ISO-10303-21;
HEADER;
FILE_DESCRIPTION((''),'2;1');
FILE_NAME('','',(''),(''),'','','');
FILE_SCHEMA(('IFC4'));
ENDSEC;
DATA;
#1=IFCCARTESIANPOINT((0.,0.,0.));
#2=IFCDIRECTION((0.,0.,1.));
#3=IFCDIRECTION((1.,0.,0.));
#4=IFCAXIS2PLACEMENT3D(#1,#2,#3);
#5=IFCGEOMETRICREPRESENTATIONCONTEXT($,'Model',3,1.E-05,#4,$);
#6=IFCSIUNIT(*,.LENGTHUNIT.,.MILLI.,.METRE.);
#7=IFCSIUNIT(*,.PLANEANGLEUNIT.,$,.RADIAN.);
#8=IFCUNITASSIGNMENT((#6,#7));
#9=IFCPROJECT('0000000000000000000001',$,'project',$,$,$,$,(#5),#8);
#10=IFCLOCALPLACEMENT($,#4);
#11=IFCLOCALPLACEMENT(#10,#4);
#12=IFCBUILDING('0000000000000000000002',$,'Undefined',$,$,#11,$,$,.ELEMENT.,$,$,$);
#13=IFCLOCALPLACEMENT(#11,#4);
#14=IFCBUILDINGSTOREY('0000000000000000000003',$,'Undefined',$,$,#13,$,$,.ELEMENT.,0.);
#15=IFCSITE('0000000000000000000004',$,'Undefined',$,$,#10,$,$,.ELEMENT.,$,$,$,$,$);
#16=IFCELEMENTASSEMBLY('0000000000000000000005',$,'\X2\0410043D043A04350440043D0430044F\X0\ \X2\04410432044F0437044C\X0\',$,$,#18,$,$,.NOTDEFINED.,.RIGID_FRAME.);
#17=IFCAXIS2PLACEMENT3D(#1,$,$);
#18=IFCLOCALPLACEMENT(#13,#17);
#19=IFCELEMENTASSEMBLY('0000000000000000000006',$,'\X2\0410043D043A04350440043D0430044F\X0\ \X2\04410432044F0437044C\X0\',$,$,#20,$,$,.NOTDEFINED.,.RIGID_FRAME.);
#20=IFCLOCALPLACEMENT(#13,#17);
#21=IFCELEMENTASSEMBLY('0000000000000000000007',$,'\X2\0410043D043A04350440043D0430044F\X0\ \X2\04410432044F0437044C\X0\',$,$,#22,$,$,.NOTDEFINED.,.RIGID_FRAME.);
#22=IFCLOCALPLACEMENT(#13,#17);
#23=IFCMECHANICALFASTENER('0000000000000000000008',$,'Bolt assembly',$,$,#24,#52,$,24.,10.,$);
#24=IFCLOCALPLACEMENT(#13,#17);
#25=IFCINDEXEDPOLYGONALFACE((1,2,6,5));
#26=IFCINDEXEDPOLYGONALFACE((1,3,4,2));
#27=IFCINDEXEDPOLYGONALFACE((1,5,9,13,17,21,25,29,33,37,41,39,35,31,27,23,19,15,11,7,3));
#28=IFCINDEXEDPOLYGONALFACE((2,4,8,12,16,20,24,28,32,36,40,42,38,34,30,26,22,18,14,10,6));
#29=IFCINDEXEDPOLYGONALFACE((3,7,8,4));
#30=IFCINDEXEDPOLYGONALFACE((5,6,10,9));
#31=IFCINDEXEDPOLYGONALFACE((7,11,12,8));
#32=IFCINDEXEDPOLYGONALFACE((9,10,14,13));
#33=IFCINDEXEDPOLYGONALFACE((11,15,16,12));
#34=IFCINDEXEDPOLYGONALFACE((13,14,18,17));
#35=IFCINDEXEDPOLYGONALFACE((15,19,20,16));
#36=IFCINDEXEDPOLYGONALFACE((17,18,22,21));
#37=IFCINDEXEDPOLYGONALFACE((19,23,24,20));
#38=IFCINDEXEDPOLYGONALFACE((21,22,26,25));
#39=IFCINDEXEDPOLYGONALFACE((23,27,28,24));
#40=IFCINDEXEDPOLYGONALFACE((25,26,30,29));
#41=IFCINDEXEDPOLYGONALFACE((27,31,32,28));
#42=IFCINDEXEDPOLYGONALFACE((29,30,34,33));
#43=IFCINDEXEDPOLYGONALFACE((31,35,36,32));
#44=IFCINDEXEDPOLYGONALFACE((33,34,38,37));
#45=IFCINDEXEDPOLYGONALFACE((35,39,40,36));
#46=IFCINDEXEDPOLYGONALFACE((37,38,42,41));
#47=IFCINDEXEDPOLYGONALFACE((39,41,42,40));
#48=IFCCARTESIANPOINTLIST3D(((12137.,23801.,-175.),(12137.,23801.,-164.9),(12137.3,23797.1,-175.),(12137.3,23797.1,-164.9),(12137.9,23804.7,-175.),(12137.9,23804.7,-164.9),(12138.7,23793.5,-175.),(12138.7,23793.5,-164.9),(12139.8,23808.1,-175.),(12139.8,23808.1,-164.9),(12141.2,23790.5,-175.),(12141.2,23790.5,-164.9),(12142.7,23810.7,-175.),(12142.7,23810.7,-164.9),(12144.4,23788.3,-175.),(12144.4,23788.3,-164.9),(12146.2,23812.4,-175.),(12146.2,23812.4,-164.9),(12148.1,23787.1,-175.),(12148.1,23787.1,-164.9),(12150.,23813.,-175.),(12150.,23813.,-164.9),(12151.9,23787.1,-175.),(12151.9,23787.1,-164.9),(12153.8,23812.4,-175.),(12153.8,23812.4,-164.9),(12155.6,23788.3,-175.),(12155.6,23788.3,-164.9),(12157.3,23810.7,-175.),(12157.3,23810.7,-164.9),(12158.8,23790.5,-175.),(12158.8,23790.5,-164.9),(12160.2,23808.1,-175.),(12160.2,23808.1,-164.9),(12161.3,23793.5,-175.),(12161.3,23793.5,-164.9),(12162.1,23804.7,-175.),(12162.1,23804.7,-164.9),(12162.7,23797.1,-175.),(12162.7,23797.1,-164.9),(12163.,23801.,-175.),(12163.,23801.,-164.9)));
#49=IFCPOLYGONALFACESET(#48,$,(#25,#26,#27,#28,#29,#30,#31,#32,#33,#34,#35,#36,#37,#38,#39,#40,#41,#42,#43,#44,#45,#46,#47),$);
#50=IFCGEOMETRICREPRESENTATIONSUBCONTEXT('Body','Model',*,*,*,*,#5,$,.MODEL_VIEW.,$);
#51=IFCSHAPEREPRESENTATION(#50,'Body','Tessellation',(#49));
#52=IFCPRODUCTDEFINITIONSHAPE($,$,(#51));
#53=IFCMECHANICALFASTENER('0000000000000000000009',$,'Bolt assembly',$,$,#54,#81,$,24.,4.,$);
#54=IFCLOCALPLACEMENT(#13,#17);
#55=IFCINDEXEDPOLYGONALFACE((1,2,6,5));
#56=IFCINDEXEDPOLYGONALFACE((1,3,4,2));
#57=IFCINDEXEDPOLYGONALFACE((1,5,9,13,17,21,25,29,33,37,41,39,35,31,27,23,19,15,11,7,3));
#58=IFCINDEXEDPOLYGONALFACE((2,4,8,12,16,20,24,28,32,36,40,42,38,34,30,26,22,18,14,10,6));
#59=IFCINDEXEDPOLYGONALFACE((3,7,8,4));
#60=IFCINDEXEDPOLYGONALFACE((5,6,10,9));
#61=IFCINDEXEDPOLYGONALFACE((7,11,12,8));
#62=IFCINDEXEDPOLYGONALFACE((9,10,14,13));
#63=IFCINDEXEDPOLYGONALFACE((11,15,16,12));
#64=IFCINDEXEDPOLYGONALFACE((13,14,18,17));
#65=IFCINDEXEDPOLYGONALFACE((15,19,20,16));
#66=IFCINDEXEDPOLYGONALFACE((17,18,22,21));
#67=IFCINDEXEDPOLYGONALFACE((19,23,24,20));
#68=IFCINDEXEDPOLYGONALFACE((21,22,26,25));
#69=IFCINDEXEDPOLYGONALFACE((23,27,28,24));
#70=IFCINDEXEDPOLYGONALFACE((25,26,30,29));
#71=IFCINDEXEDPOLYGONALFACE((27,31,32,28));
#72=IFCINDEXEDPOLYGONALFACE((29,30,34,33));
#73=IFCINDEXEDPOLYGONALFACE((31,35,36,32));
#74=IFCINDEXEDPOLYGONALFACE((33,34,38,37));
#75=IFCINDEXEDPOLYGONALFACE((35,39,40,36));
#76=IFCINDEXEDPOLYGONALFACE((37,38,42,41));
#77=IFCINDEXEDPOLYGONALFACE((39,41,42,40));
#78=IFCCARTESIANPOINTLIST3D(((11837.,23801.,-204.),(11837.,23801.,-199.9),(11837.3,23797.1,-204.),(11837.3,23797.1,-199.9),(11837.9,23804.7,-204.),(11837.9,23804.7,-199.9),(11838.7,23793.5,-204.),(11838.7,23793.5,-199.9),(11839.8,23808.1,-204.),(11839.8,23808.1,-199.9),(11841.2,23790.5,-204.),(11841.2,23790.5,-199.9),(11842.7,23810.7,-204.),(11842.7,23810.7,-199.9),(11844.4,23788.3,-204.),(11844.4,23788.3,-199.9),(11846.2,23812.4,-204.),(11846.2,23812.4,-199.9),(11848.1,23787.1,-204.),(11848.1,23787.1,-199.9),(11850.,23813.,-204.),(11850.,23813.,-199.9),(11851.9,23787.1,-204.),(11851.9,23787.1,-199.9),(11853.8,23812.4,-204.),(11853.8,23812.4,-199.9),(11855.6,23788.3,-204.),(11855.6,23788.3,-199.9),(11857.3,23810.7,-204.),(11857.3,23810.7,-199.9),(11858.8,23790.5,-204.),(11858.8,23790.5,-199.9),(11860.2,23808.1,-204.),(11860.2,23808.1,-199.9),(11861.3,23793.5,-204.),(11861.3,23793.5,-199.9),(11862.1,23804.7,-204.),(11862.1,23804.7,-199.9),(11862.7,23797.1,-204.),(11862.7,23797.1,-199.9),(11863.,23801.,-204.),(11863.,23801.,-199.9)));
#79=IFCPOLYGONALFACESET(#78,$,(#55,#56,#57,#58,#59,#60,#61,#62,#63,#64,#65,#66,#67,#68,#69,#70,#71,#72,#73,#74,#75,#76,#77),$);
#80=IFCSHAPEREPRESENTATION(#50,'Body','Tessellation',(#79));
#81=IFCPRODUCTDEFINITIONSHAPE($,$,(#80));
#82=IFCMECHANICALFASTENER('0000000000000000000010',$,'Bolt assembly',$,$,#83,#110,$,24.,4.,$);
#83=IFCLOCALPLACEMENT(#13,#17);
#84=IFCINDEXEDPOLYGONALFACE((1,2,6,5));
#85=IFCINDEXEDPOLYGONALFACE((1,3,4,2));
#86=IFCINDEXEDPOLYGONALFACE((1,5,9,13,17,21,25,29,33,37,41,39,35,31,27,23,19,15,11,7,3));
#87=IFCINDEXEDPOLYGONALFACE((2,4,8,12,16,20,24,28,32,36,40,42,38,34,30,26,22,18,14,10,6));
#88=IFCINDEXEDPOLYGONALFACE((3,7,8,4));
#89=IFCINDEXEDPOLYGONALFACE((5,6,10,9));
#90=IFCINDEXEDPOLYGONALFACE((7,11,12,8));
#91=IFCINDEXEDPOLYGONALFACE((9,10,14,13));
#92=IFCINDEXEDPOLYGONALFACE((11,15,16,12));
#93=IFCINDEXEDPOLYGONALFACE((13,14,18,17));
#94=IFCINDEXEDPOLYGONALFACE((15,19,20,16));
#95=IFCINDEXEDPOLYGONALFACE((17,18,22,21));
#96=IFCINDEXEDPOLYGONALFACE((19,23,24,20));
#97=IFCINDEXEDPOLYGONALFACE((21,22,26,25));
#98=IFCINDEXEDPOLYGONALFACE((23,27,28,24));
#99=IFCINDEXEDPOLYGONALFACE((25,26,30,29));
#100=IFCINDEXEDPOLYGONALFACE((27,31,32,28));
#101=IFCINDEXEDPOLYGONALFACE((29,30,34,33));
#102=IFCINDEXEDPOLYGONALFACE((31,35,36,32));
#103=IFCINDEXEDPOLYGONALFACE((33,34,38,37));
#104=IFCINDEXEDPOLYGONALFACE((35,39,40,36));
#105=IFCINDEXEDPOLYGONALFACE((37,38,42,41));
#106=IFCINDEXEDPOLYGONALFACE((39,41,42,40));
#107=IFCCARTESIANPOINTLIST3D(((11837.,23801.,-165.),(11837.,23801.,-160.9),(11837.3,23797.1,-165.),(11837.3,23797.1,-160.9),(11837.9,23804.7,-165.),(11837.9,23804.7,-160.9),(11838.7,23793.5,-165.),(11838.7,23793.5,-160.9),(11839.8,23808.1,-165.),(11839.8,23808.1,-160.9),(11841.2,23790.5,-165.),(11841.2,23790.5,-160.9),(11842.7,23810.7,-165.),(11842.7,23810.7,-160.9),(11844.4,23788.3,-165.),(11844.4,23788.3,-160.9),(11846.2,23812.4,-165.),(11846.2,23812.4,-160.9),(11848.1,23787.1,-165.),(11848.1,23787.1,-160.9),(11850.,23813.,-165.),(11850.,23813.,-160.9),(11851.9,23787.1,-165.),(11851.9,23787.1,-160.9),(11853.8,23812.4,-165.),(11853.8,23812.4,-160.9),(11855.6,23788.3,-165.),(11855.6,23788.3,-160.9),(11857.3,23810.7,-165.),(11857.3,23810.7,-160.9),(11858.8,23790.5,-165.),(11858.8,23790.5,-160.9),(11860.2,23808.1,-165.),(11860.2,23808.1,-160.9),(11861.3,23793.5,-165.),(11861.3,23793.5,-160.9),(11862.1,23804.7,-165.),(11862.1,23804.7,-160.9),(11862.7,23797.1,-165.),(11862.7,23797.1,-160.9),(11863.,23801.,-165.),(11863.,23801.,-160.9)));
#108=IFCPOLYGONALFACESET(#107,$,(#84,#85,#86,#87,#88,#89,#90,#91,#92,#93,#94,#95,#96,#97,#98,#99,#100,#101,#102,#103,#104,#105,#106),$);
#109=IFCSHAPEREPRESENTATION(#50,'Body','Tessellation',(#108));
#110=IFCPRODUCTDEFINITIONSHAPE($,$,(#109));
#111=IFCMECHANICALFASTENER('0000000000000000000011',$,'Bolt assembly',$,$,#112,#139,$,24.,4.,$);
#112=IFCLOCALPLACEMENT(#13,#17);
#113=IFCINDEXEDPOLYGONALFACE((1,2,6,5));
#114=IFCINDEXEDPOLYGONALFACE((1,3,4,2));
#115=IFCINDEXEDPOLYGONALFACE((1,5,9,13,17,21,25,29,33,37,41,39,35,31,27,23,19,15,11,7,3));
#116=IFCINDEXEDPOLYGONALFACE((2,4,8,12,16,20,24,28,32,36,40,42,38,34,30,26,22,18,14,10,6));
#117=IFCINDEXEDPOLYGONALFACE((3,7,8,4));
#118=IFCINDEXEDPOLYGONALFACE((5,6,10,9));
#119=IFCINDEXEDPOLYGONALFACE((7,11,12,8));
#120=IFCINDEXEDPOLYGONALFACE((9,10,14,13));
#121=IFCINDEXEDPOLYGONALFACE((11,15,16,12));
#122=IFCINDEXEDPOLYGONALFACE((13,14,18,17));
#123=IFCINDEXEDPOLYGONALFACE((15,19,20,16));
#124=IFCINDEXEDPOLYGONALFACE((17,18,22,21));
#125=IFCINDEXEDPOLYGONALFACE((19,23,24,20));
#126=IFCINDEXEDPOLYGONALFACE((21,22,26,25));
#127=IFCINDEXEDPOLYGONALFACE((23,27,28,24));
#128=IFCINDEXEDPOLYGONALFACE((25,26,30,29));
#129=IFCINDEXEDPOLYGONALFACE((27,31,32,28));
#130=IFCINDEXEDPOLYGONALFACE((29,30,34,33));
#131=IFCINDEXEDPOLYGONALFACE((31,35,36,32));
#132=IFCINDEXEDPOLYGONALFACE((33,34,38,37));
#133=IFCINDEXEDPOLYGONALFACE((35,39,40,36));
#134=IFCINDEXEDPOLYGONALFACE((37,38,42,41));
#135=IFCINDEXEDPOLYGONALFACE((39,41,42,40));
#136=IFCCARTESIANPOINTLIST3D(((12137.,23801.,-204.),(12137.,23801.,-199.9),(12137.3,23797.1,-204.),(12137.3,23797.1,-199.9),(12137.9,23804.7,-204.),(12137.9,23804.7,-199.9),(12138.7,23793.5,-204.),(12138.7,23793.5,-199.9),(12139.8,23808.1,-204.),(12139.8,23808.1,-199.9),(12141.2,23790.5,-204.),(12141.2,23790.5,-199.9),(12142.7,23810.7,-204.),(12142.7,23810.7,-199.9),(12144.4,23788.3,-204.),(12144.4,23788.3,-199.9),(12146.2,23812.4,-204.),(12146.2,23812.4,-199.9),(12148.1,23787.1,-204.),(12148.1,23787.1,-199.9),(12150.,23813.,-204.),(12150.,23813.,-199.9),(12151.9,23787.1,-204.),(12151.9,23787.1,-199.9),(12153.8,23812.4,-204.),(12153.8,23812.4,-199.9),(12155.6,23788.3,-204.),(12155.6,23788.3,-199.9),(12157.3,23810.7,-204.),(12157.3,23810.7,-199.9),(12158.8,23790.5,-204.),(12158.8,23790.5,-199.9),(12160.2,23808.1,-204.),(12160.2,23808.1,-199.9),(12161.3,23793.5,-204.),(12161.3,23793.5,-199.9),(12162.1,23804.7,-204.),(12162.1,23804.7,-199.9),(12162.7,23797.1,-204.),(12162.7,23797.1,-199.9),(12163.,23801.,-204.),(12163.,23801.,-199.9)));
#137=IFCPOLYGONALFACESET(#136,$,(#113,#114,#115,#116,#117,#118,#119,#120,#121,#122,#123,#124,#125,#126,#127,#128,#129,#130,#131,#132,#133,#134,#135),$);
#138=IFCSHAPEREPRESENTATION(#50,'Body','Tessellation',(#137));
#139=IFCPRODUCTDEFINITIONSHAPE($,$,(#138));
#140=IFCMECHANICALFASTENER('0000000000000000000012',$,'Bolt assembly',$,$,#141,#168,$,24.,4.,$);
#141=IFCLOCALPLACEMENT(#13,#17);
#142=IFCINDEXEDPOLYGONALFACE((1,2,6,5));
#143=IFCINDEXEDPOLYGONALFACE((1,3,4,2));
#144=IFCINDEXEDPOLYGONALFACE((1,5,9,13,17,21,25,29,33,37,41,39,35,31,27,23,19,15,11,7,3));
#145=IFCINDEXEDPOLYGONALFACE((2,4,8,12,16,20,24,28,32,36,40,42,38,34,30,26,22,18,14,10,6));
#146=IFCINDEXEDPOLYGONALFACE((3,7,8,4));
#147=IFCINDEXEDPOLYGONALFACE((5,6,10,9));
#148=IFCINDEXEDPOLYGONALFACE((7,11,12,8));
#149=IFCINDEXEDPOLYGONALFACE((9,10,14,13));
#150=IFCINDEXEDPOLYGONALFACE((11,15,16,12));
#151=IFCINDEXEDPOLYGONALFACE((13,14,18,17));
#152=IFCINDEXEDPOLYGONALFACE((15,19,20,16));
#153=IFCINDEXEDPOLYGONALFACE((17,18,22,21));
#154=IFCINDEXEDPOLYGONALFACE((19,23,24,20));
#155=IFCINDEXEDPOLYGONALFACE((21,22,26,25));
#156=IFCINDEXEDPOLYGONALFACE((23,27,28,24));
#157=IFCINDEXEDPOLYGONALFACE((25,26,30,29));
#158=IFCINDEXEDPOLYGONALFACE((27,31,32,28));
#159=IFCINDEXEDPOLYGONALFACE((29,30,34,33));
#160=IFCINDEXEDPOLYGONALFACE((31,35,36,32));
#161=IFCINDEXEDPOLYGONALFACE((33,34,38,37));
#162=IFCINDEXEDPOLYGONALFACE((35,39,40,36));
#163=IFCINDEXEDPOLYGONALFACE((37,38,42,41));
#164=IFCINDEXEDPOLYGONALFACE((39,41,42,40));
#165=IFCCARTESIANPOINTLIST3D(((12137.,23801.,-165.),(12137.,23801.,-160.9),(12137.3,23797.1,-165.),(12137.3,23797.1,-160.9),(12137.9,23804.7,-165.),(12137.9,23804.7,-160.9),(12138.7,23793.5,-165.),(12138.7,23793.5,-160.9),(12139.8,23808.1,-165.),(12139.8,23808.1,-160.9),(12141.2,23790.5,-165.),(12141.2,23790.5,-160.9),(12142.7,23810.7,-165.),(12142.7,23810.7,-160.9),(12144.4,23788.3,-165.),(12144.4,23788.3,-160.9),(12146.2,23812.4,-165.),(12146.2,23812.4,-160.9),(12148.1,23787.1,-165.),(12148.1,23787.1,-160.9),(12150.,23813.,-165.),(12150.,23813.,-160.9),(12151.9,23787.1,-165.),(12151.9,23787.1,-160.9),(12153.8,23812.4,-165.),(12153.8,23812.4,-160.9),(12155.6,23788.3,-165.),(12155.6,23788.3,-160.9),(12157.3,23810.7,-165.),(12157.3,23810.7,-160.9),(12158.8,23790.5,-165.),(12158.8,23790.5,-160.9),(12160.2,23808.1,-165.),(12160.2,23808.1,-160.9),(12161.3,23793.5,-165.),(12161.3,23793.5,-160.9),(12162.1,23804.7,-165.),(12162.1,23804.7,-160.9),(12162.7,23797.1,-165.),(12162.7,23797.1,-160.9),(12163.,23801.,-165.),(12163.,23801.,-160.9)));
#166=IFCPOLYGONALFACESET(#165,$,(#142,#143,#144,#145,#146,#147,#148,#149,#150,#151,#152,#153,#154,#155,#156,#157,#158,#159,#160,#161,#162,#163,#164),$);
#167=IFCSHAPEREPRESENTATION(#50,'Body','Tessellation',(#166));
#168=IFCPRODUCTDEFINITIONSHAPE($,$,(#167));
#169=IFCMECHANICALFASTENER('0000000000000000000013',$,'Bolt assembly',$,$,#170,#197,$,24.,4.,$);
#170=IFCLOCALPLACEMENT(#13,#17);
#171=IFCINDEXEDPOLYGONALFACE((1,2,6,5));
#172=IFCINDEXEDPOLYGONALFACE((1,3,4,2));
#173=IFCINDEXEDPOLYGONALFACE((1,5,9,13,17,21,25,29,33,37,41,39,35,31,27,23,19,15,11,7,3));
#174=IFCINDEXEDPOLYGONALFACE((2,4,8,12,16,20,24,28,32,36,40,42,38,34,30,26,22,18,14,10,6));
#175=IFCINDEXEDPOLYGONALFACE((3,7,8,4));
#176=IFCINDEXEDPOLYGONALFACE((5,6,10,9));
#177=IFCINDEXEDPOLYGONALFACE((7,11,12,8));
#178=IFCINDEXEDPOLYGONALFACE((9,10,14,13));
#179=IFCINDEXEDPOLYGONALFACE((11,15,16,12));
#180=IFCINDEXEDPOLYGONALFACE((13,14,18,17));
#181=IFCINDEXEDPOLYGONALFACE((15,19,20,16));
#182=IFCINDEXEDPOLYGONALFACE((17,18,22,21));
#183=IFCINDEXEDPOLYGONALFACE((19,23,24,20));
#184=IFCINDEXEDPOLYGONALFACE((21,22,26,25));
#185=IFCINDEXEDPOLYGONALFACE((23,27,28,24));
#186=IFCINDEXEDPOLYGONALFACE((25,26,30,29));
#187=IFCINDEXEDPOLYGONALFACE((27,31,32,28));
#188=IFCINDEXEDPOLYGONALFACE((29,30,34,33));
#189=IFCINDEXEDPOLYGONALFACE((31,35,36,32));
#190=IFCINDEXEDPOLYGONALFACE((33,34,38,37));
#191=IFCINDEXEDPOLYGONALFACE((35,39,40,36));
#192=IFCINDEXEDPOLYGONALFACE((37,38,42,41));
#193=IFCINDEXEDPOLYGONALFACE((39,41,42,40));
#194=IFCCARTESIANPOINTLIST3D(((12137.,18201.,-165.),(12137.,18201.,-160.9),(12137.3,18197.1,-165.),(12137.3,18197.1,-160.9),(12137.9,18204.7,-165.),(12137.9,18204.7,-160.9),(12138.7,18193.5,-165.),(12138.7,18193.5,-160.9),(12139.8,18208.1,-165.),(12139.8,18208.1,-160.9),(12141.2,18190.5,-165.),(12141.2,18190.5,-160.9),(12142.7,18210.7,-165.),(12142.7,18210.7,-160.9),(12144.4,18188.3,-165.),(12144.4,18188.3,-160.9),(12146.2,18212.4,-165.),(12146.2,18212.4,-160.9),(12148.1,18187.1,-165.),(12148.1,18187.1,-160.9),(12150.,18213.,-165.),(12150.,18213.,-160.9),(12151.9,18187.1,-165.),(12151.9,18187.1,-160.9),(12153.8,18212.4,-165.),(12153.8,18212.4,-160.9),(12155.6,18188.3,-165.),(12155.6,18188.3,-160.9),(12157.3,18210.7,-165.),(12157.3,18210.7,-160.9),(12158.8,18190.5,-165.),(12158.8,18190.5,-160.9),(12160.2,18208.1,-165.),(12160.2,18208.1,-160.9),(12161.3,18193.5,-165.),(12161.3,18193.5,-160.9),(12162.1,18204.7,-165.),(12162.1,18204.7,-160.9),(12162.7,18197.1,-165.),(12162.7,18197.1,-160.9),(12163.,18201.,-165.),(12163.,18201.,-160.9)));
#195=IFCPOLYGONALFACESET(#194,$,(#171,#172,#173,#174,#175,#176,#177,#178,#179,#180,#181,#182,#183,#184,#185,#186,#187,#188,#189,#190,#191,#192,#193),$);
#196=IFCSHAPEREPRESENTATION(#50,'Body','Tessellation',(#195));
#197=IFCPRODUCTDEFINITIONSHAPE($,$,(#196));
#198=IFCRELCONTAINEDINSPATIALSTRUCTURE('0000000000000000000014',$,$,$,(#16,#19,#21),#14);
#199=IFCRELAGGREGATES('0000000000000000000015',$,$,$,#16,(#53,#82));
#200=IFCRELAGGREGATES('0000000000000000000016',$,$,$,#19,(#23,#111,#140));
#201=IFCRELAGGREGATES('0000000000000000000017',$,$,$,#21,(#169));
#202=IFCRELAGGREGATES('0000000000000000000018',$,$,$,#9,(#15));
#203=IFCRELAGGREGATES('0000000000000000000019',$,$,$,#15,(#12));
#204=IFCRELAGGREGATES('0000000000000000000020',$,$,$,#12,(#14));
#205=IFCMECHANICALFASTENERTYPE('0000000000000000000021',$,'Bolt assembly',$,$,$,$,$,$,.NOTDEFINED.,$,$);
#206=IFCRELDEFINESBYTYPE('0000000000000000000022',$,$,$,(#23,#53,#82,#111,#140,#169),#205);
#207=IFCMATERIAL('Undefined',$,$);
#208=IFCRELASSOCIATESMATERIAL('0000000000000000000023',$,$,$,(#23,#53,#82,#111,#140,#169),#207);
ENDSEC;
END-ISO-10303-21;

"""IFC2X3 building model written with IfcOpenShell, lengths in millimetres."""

from ifc_helpers import new_model, si_unit, frame, origin_with_axes, origin_2d_with_axis, place, context, subcontext, project, spatial, circle, extrude, source, transform, mapped, material, type_object, element, aggregate, save


model = new_model("IFC2X3")

# Units and contexts
model_context = context("Model", 3, precision=1e-05, world=origin_with_axes())
body_context = subcontext(model_context, "Body", "Model", "MODEL_VIEW")
ifc_project = project(units=[si_unit("LENGTHUNIT", "METRE", prefix="MILLI"), si_unit("PLANEANGLEUNIT", "RADIAN")], contexts=[model_context])

# Site, building, storey
site_placement = place(None, origin_with_axes())
site = spatial("IfcSite", under=ifc_project, at=site_placement, Name="Undefined", CompositionType="ELEMENT")
building_placement = place(site_placement, origin_with_axes())
building = spatial("IfcBuilding", under=site, at=building_placement, Name="Undefined", CompositionType="ELEMENT")
storey_placement = place(building_placement, origin_with_axes())
storey = spatial("IfcBuildingStorey", under=building, at=storey_placement, Name="Undefined", CompositionType="ELEMENT", Elevation=0.0)

# Element assemblies
assembly_1_placement = place(storey_placement, origin_with_axes())
assembly_1 = element("IfcElementAssembly", 1, at=assembly_1_placement, inside=storey, Name="Анкерная связь", AssemblyPlace="NOTDEFINED", PredefinedType="RIGID_FRAME")
assembly_2_placement = place(storey_placement, origin_with_axes())
assembly_2 = element("IfcElementAssembly", 2, at=assembly_2_placement, inside=storey, Name="Анкерная связь", AssemblyPlace="NOTDEFINED", PredefinedType="RIGID_FRAME")
assembly_3_placement = place(storey_placement, origin_with_axes())
assembly_3 = element("IfcElementAssembly", 3, at=assembly_3_placement, inside=storey, Name="Анкерная связь", AssemblyPlace="NOTDEFINED", PredefinedType="RIGID_FRAME")

# Shared definitions
ifc_material_1 = material(Name="Undefined")
mechanical_fastener_type = type_object("IfcMechanicalFastenerType", Name="Bolt assembly")

# Mechanical fasteners
shared_shape_1 = source(origin_with_axes(), body_context, "Body", "SweptSolid", [
    extrude(circle(Radius=13.0, at=origin_2d_with_axis()), frame((0.0, 0.0, 0.0), z_axis=(0.0, 1.0, 0.0), x_axis=(1.0, 0.0, 0.0)), (0.0, 0.0, 1.0), 10.1),
])
mechanical_fastener_1_placement = place(assembly_2_placement, frame((12150.0, 23800.0, -175.0), z_axis=(1.0, 0.0, 0.0), x_axis=(0.0, 1.0, 0.0)))
mechanical_fastener_1 = element("IfcMechanicalFastener", 4, at=mechanical_fastener_1_placement, type_object=mechanical_fastener_type, material=ifc_material_1, Name="Bolt assembly", NominalDiameter=24.0, NominalLength=10.0, context=body_context, shape_type="MappedRepresentation", body=[
    mapped(shared_shape_1, transform((0.0, 0.0, 0.0))),
])
shared_shape_2 = source(origin_with_axes(), body_context, "Body", "SweptSolid", [
    extrude(circle(Radius=13.0, at=origin_2d_with_axis()), frame((0.0, -4.0, 0.0), z_axis=(0.0, 1.0, 0.0), x_axis=(1.0, 0.0, 0.0)), (0.0, 0.0, 1.0), 4.1),
])
mechanical_fastener_2_placement = place(assembly_1_placement, frame((11850.0, 23800.0, -200.0), z_axis=(1.0, 0.0, 0.0), x_axis=(0.0, 1.0, 0.0)))
mechanical_fastener_2 = element("IfcMechanicalFastener", 5, at=mechanical_fastener_2_placement, type_object=mechanical_fastener_type, material=ifc_material_1, Name="Bolt assembly", NominalDiameter=24.0, NominalLength=4.0, context=body_context, shape_type="MappedRepresentation", body=[
    mapped(shared_shape_2, transform((0.0, 0.0, 0.0))),
])
mechanical_fastener_3_placement = place(assembly_1_placement, frame((11850.0, 23800.0, -161.0), z_axis=(1.0, 0.0, 0.0), x_axis=(0.0, 1.0, 0.0)))
mechanical_fastener_3 = element("IfcMechanicalFastener", 6, at=mechanical_fastener_3_placement, type_object=mechanical_fastener_type, material=ifc_material_1, Name="Bolt assembly", NominalDiameter=24.0, NominalLength=4.0, context=body_context, shape_type="MappedRepresentation", body=[
    mapped(shared_shape_2, transform((0.0, 0.0, 0.0))),
])
aggregate(assembly_1, [mechanical_fastener_2, mechanical_fastener_3])
mechanical_fastener_4_placement = place(assembly_2_placement, frame((12150.0, 23800.0, -200.0), z_axis=(1.0, 0.0, 0.0), x_axis=(0.0, 1.0, 0.0)))
mechanical_fastener_4 = element("IfcMechanicalFastener", 7, at=mechanical_fastener_4_placement, type_object=mechanical_fastener_type, material=ifc_material_1, Name="Bolt assembly", NominalDiameter=24.0, NominalLength=4.0, context=body_context, shape_type="MappedRepresentation", body=[
    mapped(shared_shape_2, transform((0.0, 0.0, 0.0))),
])
mechanical_fastener_5_placement = place(assembly_2_placement, frame((12150.0, 23800.0, -161.0), z_axis=(1.0, 0.0, 0.0), x_axis=(0.0, 1.0, 0.0)))
mechanical_fastener_5 = element("IfcMechanicalFastener", 8, at=mechanical_fastener_5_placement, type_object=mechanical_fastener_type, material=ifc_material_1, Name="Bolt assembly", NominalDiameter=24.0, NominalLength=4.0, context=body_context, shape_type="MappedRepresentation", body=[
    mapped(shared_shape_2, transform((0.0, 0.0, 0.0))),
])
aggregate(assembly_2, [mechanical_fastener_1, mechanical_fastener_4, mechanical_fastener_5])
mechanical_fastener_6_placement = place(assembly_3_placement, frame((12150.0, 18200.0, -161.0), z_axis=(1.0, 0.0, 0.0), x_axis=(0.0, 1.0, 0.0)))
mechanical_fastener_6 = element("IfcMechanicalFastener", 9, at=mechanical_fastener_6_placement, type_object=mechanical_fastener_type, material=ifc_material_1, Name="Bolt assembly", NominalDiameter=24.0, NominalLength=4.0, context=body_context, shape_type="MappedRepresentation", body=[
    mapped(shared_shape_2, transform((0.0, 0.0, 0.0))),
])
aggregate(assembly_3, [mechanical_fastener_6])

save(model, "model.ifc")
